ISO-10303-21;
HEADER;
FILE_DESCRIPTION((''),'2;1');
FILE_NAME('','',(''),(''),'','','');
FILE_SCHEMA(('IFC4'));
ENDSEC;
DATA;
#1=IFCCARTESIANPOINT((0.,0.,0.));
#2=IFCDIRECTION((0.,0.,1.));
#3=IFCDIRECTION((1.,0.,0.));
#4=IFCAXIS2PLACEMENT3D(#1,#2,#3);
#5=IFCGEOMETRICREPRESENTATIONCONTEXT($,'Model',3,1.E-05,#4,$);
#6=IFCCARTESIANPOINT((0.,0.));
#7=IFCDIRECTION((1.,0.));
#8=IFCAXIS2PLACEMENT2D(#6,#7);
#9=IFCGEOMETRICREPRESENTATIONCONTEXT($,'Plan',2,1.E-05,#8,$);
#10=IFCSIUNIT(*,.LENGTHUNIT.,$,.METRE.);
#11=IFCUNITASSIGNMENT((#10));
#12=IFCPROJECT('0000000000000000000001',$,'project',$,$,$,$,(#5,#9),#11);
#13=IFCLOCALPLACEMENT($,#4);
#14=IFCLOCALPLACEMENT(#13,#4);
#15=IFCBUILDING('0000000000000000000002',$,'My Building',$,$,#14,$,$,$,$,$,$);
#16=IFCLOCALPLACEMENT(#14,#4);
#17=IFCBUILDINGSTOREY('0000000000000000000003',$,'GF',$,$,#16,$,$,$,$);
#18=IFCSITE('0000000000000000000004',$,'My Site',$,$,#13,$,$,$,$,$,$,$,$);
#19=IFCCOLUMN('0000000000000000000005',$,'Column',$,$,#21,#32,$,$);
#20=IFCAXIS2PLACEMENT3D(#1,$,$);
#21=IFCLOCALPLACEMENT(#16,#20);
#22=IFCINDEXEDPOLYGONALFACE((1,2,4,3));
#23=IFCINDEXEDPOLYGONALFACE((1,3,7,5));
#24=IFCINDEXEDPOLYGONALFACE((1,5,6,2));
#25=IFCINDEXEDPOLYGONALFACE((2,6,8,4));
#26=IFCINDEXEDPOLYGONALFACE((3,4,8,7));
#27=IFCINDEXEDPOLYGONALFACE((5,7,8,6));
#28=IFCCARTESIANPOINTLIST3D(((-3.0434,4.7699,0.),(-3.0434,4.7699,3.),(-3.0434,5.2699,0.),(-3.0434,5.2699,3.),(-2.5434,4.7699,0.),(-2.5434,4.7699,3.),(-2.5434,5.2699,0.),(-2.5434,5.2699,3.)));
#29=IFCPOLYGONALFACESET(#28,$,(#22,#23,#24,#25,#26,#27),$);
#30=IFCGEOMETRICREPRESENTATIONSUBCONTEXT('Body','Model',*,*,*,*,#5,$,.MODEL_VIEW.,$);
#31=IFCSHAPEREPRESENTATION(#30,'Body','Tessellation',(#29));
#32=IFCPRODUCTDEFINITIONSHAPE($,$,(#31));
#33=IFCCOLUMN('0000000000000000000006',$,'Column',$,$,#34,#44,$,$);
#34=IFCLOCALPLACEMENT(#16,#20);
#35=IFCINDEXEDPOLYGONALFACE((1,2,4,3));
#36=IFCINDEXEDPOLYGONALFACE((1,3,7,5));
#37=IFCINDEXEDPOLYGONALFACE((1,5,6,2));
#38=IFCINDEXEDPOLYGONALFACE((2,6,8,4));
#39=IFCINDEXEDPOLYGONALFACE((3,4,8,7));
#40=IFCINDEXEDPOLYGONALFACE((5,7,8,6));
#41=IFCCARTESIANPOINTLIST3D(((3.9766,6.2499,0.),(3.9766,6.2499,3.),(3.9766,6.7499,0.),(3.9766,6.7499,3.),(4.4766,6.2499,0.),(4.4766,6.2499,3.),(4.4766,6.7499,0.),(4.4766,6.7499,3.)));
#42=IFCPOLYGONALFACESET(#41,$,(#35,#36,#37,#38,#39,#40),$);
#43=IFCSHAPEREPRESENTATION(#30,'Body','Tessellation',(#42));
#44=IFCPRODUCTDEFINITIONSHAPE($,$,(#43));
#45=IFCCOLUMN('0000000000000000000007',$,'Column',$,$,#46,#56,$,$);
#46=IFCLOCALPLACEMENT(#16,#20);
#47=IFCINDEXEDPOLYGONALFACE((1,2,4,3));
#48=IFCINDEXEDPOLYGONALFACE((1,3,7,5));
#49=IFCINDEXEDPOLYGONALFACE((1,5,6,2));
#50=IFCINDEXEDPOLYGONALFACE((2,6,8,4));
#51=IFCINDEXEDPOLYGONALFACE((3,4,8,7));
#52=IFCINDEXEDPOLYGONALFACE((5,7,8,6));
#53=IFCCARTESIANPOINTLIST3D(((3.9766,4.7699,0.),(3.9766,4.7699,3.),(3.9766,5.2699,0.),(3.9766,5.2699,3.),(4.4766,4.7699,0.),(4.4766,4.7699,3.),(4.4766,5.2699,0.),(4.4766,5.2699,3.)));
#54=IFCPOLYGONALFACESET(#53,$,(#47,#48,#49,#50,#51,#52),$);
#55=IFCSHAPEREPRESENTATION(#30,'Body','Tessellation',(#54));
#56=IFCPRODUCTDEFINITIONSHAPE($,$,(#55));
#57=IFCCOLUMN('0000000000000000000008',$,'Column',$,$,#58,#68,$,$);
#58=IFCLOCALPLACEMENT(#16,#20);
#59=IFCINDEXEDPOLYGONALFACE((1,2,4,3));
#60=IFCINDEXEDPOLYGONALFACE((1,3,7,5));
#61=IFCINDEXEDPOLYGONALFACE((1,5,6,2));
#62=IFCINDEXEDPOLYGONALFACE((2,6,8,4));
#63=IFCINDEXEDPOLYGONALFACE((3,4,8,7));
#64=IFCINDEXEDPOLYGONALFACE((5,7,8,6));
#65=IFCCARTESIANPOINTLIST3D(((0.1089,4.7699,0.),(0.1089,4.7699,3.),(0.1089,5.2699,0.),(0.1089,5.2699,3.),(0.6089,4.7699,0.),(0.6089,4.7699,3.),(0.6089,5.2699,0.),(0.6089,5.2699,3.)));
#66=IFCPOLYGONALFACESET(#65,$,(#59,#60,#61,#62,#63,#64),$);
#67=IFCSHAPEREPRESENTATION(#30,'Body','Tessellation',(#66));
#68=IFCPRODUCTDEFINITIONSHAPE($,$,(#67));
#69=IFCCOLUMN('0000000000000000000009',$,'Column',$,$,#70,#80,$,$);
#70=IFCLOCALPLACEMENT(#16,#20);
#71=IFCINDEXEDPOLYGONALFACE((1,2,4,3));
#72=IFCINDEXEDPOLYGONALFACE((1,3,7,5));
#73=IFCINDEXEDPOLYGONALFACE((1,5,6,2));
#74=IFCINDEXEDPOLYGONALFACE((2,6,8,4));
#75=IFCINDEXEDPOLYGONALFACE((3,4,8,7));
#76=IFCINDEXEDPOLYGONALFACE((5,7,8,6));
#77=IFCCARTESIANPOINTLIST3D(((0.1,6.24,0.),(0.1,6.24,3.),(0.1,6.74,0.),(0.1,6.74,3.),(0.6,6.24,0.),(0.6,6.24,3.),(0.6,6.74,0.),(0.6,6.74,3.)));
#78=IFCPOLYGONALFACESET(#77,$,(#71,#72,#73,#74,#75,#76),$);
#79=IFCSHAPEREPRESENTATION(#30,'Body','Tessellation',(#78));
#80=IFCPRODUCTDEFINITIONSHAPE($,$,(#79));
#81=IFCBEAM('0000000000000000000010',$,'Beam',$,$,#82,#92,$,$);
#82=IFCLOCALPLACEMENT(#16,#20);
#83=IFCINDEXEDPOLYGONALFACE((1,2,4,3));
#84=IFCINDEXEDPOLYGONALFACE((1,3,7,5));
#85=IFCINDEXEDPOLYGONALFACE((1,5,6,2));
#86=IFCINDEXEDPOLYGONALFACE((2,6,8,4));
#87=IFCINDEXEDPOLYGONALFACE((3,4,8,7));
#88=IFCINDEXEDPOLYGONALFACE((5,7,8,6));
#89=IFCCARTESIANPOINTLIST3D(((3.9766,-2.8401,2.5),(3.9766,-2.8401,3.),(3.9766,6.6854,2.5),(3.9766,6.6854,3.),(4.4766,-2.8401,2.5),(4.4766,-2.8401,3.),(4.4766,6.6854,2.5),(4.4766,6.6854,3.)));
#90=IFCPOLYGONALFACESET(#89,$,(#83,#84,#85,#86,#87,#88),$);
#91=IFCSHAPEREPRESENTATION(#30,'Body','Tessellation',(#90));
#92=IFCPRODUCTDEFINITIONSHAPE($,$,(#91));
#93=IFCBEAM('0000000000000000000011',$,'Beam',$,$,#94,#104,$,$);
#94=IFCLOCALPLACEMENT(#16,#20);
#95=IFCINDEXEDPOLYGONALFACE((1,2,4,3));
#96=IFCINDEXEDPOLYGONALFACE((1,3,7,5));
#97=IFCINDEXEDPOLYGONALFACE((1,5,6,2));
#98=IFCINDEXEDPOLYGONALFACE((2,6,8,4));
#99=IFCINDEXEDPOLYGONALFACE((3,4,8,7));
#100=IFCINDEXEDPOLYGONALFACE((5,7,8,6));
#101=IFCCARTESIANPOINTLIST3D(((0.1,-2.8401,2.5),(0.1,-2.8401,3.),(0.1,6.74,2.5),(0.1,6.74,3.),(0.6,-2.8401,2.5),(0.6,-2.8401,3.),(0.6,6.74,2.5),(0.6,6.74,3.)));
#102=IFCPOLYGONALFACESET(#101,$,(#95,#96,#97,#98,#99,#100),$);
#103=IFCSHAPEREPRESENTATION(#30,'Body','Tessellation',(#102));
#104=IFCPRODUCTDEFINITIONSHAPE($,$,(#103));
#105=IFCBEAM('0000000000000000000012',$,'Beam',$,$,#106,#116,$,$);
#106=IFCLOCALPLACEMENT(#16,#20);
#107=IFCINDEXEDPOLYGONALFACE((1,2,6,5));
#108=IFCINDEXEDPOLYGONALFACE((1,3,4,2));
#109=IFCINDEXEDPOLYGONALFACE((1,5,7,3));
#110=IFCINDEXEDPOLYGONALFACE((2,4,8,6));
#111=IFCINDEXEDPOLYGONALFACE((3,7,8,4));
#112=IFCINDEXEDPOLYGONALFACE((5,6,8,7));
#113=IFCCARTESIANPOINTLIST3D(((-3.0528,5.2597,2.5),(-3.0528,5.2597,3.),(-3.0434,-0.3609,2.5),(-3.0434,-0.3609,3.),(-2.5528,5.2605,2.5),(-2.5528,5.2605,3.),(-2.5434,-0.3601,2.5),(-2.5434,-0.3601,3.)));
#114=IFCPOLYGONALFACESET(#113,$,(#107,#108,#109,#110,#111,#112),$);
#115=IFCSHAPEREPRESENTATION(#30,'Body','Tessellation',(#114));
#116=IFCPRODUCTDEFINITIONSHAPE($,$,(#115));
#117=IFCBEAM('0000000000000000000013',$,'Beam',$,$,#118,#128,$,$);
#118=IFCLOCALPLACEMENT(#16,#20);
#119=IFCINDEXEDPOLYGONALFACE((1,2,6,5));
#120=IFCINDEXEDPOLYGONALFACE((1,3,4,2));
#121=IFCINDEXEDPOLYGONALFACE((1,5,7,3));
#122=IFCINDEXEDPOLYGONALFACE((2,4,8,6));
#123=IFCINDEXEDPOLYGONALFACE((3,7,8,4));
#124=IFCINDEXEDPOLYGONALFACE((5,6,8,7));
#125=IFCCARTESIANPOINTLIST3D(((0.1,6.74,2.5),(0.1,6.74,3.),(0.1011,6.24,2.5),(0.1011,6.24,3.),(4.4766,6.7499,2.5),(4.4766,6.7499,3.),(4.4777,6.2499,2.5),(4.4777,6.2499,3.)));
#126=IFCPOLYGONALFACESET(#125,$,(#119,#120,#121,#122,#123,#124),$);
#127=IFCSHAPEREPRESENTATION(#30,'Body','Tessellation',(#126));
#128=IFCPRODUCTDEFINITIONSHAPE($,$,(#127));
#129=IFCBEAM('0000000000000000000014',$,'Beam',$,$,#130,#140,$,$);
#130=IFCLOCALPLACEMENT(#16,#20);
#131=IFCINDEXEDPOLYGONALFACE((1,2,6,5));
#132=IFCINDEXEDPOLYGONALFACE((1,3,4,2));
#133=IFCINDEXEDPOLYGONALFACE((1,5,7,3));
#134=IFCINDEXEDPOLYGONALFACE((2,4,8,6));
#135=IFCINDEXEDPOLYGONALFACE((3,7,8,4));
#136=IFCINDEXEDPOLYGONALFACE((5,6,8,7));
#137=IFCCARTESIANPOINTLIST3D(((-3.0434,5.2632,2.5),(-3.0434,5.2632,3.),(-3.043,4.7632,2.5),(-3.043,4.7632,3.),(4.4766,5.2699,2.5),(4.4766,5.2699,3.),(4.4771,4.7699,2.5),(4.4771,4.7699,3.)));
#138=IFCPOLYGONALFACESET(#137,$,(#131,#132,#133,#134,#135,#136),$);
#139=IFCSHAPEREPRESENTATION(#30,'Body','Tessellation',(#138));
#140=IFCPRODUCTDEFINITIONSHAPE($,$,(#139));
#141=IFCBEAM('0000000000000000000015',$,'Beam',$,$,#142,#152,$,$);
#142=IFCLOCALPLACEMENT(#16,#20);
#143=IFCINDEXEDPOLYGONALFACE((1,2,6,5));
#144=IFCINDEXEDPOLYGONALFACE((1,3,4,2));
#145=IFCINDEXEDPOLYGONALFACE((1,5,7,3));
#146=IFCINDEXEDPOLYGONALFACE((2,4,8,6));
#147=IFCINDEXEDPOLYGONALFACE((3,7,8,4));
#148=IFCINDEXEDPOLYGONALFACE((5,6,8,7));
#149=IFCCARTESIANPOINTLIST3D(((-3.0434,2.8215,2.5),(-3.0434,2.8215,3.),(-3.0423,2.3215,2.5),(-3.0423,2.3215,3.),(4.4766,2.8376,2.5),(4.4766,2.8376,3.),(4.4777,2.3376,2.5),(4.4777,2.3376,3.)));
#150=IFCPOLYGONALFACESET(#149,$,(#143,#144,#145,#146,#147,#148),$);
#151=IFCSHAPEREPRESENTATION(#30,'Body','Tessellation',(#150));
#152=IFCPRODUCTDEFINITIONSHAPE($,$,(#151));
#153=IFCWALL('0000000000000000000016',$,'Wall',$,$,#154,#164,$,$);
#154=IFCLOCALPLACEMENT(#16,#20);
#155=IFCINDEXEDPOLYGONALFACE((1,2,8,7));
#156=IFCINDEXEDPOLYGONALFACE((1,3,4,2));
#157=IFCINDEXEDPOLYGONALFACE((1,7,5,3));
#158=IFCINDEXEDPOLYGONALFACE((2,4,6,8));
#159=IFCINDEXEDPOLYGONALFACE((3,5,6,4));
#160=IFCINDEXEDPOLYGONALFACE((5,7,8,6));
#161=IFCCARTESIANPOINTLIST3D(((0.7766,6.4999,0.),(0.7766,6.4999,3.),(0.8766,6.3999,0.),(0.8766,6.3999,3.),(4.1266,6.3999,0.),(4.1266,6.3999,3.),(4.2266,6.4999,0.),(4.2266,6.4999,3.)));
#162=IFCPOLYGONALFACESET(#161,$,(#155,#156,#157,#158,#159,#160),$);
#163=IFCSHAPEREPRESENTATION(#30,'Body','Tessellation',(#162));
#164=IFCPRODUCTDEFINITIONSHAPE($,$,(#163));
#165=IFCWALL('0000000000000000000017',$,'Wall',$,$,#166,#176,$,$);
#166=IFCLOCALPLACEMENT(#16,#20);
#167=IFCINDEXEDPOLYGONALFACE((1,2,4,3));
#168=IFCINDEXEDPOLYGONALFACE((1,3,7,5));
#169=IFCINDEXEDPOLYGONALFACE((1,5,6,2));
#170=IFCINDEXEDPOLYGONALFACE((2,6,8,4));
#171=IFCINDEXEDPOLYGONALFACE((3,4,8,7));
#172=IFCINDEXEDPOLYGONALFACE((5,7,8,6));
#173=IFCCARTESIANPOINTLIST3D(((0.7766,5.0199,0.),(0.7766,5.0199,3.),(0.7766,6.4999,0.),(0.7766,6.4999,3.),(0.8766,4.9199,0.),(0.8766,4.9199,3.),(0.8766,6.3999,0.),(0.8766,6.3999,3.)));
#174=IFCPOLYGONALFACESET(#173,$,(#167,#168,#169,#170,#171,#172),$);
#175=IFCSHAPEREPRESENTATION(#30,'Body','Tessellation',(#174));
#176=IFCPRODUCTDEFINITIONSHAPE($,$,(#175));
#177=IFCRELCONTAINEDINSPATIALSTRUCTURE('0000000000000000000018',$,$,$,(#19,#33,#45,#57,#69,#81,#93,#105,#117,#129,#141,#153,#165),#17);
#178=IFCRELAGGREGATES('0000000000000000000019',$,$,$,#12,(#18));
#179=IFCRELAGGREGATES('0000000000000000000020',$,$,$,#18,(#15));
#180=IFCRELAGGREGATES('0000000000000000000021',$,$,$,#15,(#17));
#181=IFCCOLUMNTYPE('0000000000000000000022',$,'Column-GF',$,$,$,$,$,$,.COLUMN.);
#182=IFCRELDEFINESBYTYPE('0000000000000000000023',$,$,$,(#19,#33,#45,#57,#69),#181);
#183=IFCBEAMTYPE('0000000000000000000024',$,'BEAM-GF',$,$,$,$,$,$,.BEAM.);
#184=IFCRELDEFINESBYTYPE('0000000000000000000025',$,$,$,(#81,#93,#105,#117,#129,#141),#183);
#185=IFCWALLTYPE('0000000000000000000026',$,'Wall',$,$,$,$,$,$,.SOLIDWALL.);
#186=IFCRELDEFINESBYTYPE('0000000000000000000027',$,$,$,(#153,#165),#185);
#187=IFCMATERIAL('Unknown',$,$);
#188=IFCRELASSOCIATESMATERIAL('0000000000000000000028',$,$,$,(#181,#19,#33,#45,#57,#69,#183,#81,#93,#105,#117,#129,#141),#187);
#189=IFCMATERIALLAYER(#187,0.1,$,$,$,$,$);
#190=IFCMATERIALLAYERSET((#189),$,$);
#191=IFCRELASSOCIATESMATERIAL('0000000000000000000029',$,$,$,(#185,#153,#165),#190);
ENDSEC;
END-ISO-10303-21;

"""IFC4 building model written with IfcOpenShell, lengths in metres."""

from ifc_helpers import new_model, si_unit, frame, origin_with_axes, origin_2d_with_axis, place, context, subcontext, project, spatial, line, indexed_curve, rectangle, outline, extrude, material, layer, layer_set, layer_usage, material_profile, profile_set, profile_usage, type_object, element, save


model = new_model("IFC4")

# Units and contexts
model_context = context("Model", 3, precision=1e-05, world=origin_with_axes())
plan_context = context("Plan", 2, precision=1e-05, world=origin_2d_with_axis())
body_context_1 = subcontext(model_context, "Body", "Model", "MODEL_VIEW")
ifc_project = project(units=[si_unit("LENGTHUNIT", "METRE")], contexts=[model_context, plan_context])

# Site, building, storey
site_placement = place(None, origin_with_axes())
site = spatial("IfcSite", under=ifc_project, at=site_placement, Name="My Site")
building_placement = place(site_placement, origin_with_axes())
building = spatial("IfcBuilding", under=site, at=building_placement, Name="My Building")
storey_placement = place(building_placement, origin_with_axes())
storey = spatial("IfcBuildingStorey", under=building, at=storey_placement, Name="GF")

# Columns
ifc_material = material(Name="Unknown")
ifc_material_profile_1 = material_profile(ifc_material, rectangle(XDim=0.5, YDim=0.5))
ifc_profile_set_1 = profile_set([ifc_material_profile_1])
ifc_profile_usage_1 = profile_usage(ifc_profile_set_1, cardinal=5)
column_type = type_object("IfcColumnType", Name="Column-GF", PredefinedType="COLUMN", material=ifc_profile_set_1)
column_1_placement = place(storey_placement, frame((-2.7934, 5.0199, 0.0), z_axis=(0.0, 0.0, 1.0), x_axis=(1.0, 0.0, 0.0)))
element("IfcColumn", 1, at=column_1_placement, inside=storey, type_object=column_type, material=ifc_profile_usage_1, Name="Column", context=body_context_1, shape_type="SweptSolid", body=[
    extrude(rectangle(XDim=0.5, YDim=0.5), origin_with_axes(), (0.0, 0.0, 1.0), 3.0),
])
ifc_profile_usage_2 = profile_usage(ifc_profile_set_1, cardinal=5)
column_2_placement = place(storey_placement, frame((4.2266, 6.4999, 0.0), z_axis=(0.0, 0.0, 1.0), x_axis=(1.0, 0.0, 0.0)))
element("IfcColumn", 2, at=column_2_placement, inside=storey, type_object=column_type, material=ifc_profile_usage_2, Name="Column", context=body_context_1, shape_type="SweptSolid", body=[
    extrude(rectangle(XDim=0.5, YDim=0.5), origin_with_axes(), (0.0, 0.0, 1.0), 3.0),
])
ifc_profile_usage_3 = profile_usage(ifc_profile_set_1, cardinal=5)
column_3_placement = place(storey_placement, frame((4.2266, 5.0199, 0.0), z_axis=(0.0, 0.0, 1.0), x_axis=(1.0, 0.0, 0.0)))
element("IfcColumn", 3, at=column_3_placement, inside=storey, type_object=column_type, material=ifc_profile_usage_3, Name="Column", context=body_context_1, shape_type="SweptSolid", body=[
    extrude(rectangle(XDim=0.5, YDim=0.5), origin_with_axes(), (0.0, 0.0, 1.0), 3.0),
])
ifc_profile_usage_4 = profile_usage(ifc_profile_set_1, cardinal=5)
column_4_placement = place(storey_placement, frame((0.3589, 5.0199, 0.0), z_axis=(0.0, 0.0, 1.0), x_axis=(1.0, 0.0, 0.0)))
element("IfcColumn", 4, at=column_4_placement, inside=storey, type_object=column_type, material=ifc_profile_usage_4, Name="Column", context=body_context_1, shape_type="SweptSolid", body=[
    extrude(rectangle(XDim=0.5, YDim=0.5), origin_with_axes(), (0.0, 0.0, 1.0), 3.0),
])
ifc_profile_usage_5 = profile_usage(ifc_profile_set_1, cardinal=5)
column_5_placement = place(storey_placement, frame((0.35, 6.49, 0.0), z_axis=(0.0, 0.0, 1.0), x_axis=(1.0, 0.0, 0.0)))
element("IfcColumn", 5, at=column_5_placement, inside=storey, type_object=column_type, material=ifc_profile_usage_5, Name="Column", context=body_context_1, shape_type="SweptSolid", body=[
    extrude(rectangle(XDim=0.5, YDim=0.5), origin_with_axes(), (0.0, 0.0, 1.0), 3.0),
])

# Beams
ifc_material_profile_2 = material_profile(ifc_material, rectangle(XDim=0.5, YDim=0.5))
ifc_profile_set_2 = profile_set([ifc_material_profile_2])
ifc_profile_usage_6 = profile_usage(ifc_profile_set_2, cardinal=7)
beam_type = type_object("IfcBeamType", Name="BEAM-GF", PredefinedType="BEAM", material=ifc_profile_set_2)
beam_1_placement = place(storey_placement, frame((4.4766, 6.6854, 3.0), z_axis=(0.0, -1.0, 0.0), x_axis=(1.0, 0.0, 0.0)))
element("IfcBeam", 6, at=beam_1_placement, inside=storey, type_object=beam_type, material=ifc_profile_usage_6, Name="Beam", context=body_context_1, shape_type="SweptSolid", body=[
    extrude(rectangle(XDim=0.5, YDim=0.5), frame((-0.25, -0.25, 0.0), z_axis=(0.0, 0.0, 1.0), x_axis=(1.0, 0.0, 0.0)), (0.0, 0.0, 1.0), 9.5255),
])
ifc_profile_usage_7 = profile_usage(ifc_profile_set_2, cardinal=7)
beam_2_placement = place(storey_placement, frame((0.6, 6.74, 3.0), z_axis=(0.0, -1.0, 0.0), x_axis=(1.0, 0.0, 0.0)))
element("IfcBeam", 7, at=beam_2_placement, inside=storey, type_object=beam_type, material=ifc_profile_usage_7, Name="Beam", context=body_context_1, shape_type="SweptSolid", body=[
    extrude(rectangle(XDim=0.5, YDim=0.5), frame((-0.25, -0.25, 0.0), z_axis=(0.0, 0.0, 1.0), x_axis=(1.0, 0.0, 0.0)), (0.0, 0.0, 1.0), 9.5801),
])
ifc_profile_usage_8 = profile_usage(ifc_profile_set_2, cardinal=7)
beam_3_placement = place(storey_placement, frame((-2.5528, 5.2605, 3.0), z_axis=(0.00167, -0.999999, 0.0), x_axis=(0.999999, 0.00167, 0.0)))
element("IfcBeam", 8, at=beam_3_placement, inside=storey, type_object=beam_type, material=ifc_profile_usage_8, Name="Beam", context=body_context_1, shape_type="SweptSolid", body=[
    extrude(rectangle(XDim=0.5, YDim=0.5), frame((-0.25, -0.25, 0.0), z_axis=(0.0, 0.0, 1.0), x_axis=(1.0, 0.0, 0.0)), (0.0, 0.0, 1.0), 5.6206),
])
ifc_profile_usage_9 = profile_usage(ifc_profile_set_2, cardinal=7)
beam_4_placement = place(storey_placement, frame((0.1, 6.74, 3.0), z_axis=(0.999997, 0.002261, 0.0), x_axis=(-0.002261, 0.999997, 0.0)))
element("IfcBeam", 9, at=beam_4_placement, inside=storey, type_object=beam_type, material=ifc_profile_usage_9, Name="Beam", context=body_context_1, shape_type="SweptSolid", body=[
    extrude(rectangle(XDim=0.5, YDim=0.5), frame((-0.25, -0.25, 0.0), z_axis=(0.0, 0.0, 1.0), x_axis=(1.0, 0.0, 0.0)), (0.0, 0.0, 1.0), 4.3766),
])
ifc_profile_usage_10 = profile_usage(ifc_profile_set_2, cardinal=7)
beam_5_placement = place(storey_placement, frame((-3.0434, 5.2632, 3.0), z_axis=(1.0, 0.000895, 0.0), x_axis=(-0.000895, 1.0, 0.0)))
element("IfcBeam", 10, at=beam_5_placement, inside=storey, type_object=beam_type, material=ifc_profile_usage_10, Name="Beam", context=body_context_1, shape_type="SweptSolid", body=[
    extrude(rectangle(XDim=0.5, YDim=0.5), frame((-0.25, -0.25, 0.0), z_axis=(0.0, 0.0, 1.0), x_axis=(1.0, 0.0, 0.0)), (0.0, 0.0, 1.0), 7.52),
])
ifc_profile_usage_11 = profile_usage(ifc_profile_set_2, cardinal=7)
beam_6_placement = place(storey_placement, frame((-3.0434, 2.8215, 3.0), z_axis=(0.999998, 0.002139, 0.0), x_axis=(-0.002139, 0.999998, 0.0)))
element("IfcBeam", 11, at=beam_6_placement, inside=storey, type_object=beam_type, material=ifc_profile_usage_11, Name="Beam", context=body_context_1, shape_type="SweptSolid", body=[
    extrude(rectangle(XDim=0.5, YDim=0.5), frame((-0.25, -0.25, 0.0), z_axis=(0.0, 0.0, 1.0), x_axis=(1.0, 0.0, 0.0)), (0.0, 0.0, 1.0), 7.52),
])

# Walls
ifc_layer = layer(ifc_material, 0.1)
ifc_layer_set = layer_set([ifc_layer])
ifc_layer_usage_1 = layer_usage(ifc_layer_set, "AXIS2", "POSITIVE", 0.0)
wall_type = type_object("IfcWallType", Name="Wall", PredefinedType="SOLIDWALL", material=ifc_layer_set)
wall_1_placement = place(storey_placement, frame((4.2266, 6.4999, 0.0), z_axis=(0.0, 0.0, 1.0), x_axis=(-1.0, 0.0, 0.0)))
element("IfcWall", 12, at=wall_1_placement, inside=storey, type_object=wall_type, material=ifc_layer_usage_1, Name="Wall", context=body_context_1, shape_type="SweptSolid", body=[
    extrude(outline(indexed_curve([(0.0, 0.0), (0.1, 0.1), (3.35, 0.1), (3.45, 0.0)], segments=[line(1, 2, 3, 4, 1)])), origin_with_axes(), (0.0, 0.0, 1.0), 3.0),
])
ifc_layer_usage_2 = layer_usage(ifc_layer_set, "AXIS2", "POSITIVE", 0.0)
wall_2_placement = place(storey_placement, frame((0.7766, 6.4999, 0.0), z_axis=(0.0, 0.0, 1.0), x_axis=(0.0, -1.0, 0.0)))
element("IfcWall", 13, at=wall_2_placement, inside=storey, type_object=wall_type, material=ifc_layer_usage_2, Name="Wall", context=body_context_1, shape_type="SweptSolid", body=[
    extrude(outline(indexed_curve([(0.0, 0.0), (0.1, 0.1), (1.58, 0.1), (1.48, 0.0)], segments=[line(1, 2, 3, 4, 1)])), origin_with_axes(), (0.0, 0.0, 1.0), 3.0),
])

save(model, "model.ifc")
